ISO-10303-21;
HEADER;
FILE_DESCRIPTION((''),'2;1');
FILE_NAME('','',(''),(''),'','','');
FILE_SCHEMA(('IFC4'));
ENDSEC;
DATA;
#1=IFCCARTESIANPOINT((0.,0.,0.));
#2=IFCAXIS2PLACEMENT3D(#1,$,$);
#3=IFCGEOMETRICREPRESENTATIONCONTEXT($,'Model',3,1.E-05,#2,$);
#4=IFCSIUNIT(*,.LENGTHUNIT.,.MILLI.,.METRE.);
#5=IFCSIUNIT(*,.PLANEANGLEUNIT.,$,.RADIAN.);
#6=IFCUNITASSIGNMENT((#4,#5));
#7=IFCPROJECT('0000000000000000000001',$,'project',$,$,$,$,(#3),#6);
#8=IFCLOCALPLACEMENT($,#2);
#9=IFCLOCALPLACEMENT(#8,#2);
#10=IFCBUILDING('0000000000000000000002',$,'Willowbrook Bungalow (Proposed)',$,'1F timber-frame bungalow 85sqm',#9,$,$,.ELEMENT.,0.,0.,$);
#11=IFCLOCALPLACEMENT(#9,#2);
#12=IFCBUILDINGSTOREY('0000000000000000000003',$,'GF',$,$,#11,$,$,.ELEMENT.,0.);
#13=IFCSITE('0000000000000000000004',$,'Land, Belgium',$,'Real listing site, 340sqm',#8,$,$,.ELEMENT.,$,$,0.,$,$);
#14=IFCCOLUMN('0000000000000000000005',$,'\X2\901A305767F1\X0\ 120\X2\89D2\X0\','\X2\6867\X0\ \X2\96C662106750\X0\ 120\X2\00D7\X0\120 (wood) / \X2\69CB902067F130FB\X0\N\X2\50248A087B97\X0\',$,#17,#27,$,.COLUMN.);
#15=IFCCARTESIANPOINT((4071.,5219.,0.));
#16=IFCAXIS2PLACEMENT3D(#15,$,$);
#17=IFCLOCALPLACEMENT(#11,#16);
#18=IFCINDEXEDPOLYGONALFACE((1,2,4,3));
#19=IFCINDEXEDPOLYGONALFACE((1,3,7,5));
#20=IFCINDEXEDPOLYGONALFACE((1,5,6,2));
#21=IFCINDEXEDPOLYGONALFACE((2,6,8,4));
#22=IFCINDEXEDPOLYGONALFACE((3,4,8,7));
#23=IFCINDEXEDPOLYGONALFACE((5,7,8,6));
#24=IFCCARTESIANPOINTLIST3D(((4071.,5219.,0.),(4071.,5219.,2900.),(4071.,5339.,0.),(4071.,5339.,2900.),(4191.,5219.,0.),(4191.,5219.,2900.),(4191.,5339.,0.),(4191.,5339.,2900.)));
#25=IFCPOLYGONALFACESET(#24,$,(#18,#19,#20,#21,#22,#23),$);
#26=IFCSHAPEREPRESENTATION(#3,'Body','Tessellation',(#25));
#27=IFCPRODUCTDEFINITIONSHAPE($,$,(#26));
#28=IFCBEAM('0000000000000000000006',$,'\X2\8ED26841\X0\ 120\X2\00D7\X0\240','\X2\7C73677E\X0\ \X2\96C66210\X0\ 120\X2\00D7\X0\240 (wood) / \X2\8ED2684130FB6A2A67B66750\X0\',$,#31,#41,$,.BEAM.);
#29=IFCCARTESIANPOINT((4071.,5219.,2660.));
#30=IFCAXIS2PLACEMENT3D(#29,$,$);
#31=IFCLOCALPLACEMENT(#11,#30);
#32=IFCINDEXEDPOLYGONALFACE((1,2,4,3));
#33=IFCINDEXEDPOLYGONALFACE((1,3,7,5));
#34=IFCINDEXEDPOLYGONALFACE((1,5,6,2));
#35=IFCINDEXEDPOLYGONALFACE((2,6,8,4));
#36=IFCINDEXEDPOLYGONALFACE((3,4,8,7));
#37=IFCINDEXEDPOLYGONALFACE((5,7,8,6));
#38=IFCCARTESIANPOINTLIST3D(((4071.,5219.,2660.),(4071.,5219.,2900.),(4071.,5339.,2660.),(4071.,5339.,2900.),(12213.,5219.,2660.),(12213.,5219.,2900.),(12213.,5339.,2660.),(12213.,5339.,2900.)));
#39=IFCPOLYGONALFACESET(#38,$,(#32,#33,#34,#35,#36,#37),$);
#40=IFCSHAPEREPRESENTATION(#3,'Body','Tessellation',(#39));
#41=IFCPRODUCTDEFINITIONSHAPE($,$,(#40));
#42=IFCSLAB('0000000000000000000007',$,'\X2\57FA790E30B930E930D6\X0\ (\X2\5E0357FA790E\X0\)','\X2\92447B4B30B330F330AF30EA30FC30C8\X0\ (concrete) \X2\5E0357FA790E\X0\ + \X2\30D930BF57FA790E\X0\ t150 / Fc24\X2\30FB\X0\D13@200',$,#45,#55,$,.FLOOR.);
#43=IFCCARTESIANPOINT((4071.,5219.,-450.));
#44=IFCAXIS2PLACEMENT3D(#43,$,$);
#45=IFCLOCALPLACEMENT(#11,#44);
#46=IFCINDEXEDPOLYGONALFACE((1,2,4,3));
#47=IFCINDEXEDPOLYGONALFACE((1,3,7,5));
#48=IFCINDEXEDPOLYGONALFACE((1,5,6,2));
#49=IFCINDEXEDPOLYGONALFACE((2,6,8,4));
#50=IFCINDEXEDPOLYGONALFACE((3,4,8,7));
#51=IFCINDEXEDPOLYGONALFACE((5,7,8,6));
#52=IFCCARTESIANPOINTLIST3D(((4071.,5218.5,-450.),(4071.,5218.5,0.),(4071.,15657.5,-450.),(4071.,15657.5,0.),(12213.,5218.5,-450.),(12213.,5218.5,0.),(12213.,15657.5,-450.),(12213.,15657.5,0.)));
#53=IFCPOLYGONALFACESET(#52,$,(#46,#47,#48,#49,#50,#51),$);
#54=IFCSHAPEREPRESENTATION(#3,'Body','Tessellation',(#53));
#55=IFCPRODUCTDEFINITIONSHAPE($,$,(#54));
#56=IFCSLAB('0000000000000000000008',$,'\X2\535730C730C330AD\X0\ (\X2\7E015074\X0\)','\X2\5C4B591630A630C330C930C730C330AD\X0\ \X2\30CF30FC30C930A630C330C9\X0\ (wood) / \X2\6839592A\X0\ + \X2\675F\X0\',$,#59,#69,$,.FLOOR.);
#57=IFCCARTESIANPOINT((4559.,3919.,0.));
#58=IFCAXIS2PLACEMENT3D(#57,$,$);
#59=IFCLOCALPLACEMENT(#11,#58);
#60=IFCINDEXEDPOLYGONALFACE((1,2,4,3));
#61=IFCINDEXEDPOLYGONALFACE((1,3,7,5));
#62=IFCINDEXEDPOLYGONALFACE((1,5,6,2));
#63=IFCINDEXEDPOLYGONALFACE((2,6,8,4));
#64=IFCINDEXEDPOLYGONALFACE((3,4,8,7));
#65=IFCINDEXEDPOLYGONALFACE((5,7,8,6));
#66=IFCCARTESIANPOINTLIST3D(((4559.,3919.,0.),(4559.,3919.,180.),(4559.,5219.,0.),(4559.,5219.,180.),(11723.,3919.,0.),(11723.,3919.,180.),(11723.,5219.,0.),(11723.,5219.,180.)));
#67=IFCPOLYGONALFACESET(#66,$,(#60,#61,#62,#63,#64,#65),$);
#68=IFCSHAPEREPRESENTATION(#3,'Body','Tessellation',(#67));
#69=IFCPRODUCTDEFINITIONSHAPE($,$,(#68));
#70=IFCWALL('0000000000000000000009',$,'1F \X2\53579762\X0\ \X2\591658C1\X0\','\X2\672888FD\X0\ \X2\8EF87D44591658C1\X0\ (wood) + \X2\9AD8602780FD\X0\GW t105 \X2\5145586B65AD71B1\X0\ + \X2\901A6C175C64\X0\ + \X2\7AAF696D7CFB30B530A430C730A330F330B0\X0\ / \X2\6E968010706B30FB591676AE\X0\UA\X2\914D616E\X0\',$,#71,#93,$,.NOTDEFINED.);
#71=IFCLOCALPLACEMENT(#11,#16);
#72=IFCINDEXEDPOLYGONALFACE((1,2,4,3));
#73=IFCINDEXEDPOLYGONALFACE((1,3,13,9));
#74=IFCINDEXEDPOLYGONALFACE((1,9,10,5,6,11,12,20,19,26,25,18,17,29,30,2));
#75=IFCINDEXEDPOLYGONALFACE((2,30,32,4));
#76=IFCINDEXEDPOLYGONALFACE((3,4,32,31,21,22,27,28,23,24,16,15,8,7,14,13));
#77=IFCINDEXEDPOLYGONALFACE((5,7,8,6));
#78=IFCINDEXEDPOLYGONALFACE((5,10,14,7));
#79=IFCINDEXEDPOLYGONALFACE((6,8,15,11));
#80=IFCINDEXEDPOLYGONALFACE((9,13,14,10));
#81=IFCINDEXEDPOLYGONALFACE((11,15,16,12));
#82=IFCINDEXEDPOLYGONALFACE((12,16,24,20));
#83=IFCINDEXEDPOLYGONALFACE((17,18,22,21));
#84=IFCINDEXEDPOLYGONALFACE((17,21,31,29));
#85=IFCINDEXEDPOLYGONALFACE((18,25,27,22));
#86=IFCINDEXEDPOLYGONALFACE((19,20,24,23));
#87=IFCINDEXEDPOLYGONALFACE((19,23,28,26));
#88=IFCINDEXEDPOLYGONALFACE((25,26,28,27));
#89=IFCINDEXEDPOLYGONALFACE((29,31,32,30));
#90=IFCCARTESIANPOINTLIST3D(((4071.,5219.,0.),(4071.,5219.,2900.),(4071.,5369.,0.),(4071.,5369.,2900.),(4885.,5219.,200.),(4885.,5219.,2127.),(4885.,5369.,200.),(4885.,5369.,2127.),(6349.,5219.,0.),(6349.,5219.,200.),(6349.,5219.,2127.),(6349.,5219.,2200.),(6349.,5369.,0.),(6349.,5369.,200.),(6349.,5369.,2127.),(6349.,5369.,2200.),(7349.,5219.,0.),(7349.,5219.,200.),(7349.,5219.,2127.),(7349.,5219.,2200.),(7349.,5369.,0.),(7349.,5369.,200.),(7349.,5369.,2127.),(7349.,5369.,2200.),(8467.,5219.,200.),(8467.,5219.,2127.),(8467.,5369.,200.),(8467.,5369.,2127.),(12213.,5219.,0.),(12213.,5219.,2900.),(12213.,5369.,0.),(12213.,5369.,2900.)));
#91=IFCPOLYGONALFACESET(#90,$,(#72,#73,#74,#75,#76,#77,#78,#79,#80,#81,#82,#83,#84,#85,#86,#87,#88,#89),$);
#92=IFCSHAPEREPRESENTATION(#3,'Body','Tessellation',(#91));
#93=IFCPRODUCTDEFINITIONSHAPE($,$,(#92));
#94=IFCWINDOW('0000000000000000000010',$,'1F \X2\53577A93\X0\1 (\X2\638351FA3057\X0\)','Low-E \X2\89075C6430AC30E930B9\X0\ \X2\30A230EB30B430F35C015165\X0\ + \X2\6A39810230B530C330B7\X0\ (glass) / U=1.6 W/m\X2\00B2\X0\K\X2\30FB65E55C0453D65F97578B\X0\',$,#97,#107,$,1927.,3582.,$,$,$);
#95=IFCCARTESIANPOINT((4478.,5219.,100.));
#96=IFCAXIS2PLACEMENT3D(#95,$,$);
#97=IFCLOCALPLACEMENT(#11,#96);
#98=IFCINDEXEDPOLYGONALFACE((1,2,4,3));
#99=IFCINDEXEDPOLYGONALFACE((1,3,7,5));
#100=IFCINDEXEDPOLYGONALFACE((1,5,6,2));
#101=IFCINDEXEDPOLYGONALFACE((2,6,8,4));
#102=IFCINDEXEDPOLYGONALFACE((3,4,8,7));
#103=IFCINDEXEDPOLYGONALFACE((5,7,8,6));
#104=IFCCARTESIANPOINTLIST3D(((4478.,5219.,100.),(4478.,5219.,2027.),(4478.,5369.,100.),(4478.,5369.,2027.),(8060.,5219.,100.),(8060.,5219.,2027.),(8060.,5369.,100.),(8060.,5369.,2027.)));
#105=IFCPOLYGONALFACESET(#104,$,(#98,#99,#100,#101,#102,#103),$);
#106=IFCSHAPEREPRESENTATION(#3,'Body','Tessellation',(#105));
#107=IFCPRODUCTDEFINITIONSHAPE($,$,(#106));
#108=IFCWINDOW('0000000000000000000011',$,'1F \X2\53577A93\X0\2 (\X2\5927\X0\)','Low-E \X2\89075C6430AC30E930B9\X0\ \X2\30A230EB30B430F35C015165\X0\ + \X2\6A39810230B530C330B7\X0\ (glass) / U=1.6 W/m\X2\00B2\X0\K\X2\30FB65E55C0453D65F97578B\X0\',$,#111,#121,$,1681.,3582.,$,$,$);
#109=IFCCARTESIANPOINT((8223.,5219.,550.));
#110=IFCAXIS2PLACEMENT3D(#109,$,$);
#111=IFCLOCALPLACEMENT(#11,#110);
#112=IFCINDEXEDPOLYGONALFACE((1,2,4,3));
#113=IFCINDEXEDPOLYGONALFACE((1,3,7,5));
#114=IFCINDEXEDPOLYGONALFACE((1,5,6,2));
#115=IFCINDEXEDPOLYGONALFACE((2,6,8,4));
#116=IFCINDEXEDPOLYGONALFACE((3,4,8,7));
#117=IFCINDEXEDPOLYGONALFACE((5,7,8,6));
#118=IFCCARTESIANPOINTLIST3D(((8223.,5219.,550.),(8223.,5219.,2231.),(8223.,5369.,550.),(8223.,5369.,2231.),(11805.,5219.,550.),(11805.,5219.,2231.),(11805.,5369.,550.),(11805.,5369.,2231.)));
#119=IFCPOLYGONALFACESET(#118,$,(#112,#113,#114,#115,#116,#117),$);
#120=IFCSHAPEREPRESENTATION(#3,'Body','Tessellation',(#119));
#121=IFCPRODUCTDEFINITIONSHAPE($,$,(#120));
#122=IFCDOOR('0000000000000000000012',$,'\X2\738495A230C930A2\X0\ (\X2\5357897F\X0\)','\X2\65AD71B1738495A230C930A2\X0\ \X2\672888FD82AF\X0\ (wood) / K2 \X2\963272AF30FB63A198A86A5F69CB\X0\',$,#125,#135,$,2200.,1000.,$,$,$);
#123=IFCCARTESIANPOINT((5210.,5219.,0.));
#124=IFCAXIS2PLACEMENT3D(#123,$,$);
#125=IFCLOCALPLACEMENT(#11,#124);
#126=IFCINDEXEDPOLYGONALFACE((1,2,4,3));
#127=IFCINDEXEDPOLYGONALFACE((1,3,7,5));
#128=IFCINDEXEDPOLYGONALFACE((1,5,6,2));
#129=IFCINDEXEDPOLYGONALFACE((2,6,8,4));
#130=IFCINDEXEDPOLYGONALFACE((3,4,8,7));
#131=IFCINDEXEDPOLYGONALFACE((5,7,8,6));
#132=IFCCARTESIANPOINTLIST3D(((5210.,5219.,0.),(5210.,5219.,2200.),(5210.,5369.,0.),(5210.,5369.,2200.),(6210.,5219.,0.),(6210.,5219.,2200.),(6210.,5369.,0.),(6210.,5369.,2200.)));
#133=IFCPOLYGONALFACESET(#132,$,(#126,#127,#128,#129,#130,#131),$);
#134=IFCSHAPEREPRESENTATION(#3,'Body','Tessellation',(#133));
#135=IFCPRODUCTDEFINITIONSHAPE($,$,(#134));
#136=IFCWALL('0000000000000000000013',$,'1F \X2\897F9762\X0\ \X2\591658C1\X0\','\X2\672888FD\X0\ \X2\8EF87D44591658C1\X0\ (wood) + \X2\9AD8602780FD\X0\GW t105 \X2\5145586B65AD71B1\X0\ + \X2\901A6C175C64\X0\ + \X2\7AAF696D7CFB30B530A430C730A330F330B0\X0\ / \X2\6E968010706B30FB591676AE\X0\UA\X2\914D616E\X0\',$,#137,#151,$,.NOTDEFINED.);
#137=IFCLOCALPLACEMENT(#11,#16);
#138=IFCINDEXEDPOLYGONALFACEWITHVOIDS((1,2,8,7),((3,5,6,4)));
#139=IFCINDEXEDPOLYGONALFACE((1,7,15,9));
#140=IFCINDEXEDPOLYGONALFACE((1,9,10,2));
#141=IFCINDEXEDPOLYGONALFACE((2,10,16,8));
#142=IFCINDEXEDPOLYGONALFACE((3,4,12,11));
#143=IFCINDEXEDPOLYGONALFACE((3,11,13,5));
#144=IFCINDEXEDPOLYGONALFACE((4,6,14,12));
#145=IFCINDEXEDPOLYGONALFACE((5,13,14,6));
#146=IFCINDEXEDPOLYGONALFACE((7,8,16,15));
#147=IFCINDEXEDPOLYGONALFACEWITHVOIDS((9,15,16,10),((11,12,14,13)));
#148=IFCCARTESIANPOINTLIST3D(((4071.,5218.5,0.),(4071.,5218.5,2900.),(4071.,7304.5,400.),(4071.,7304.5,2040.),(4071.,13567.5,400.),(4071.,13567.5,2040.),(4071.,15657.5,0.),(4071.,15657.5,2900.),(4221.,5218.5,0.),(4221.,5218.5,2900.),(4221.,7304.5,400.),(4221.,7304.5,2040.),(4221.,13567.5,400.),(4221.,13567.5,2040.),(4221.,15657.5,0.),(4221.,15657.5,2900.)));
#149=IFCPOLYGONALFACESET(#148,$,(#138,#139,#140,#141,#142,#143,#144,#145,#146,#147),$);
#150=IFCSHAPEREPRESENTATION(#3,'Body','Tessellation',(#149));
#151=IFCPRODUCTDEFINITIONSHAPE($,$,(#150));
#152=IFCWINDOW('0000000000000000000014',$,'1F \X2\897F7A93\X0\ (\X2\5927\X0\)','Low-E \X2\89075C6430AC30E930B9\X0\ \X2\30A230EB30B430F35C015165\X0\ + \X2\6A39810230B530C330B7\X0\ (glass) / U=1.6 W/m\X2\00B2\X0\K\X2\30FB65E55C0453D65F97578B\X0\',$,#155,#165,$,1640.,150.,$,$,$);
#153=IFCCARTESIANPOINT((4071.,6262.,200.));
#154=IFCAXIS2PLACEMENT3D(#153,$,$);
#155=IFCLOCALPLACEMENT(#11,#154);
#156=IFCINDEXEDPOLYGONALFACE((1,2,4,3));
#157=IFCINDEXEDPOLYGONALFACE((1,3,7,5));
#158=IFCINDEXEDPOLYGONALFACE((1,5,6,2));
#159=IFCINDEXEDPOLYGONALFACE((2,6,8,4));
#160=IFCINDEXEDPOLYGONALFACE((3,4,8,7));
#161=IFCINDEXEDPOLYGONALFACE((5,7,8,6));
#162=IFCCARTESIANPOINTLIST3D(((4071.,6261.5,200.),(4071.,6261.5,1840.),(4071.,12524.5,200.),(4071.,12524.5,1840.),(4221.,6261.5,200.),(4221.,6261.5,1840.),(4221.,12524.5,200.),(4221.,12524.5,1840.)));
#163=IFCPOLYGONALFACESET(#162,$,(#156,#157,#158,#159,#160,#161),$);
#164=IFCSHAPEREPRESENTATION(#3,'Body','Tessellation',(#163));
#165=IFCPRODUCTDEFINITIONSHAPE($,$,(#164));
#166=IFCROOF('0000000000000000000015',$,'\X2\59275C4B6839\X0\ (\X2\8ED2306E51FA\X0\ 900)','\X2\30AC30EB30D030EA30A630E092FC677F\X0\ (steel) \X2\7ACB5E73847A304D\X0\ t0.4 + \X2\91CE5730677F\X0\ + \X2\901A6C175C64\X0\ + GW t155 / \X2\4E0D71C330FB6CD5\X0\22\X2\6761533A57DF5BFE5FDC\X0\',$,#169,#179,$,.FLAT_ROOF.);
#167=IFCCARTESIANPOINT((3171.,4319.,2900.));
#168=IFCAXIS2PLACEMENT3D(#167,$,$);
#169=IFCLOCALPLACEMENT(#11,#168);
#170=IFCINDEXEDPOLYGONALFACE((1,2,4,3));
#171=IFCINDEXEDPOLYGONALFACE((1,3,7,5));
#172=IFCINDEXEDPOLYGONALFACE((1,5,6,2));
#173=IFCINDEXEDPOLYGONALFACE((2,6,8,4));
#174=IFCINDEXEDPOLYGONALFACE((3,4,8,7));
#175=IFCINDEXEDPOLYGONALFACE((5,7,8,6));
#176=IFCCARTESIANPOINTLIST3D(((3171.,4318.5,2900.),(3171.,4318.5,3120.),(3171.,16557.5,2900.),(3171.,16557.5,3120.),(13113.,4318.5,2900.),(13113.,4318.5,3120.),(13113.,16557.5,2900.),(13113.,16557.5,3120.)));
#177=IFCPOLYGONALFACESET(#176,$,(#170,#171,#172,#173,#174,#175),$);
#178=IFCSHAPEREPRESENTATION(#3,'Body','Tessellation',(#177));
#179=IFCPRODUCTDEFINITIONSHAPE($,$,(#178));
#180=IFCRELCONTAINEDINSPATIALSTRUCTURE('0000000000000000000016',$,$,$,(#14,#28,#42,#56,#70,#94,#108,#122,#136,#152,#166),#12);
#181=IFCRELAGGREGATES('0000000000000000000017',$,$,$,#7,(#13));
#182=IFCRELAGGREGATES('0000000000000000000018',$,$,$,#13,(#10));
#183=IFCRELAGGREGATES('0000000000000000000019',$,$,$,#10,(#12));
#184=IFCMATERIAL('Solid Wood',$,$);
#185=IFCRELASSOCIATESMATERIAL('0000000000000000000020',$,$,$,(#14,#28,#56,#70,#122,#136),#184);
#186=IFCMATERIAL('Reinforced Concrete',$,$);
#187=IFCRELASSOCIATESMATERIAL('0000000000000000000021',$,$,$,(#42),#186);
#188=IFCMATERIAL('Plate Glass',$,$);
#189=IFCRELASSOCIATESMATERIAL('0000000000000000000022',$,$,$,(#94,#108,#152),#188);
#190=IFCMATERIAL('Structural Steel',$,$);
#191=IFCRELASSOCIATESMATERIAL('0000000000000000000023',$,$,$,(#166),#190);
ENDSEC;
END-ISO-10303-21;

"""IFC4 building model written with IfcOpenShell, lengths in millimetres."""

from ifc_helpers import new_model, si_unit, frame, frame_2d, origin, place, context, project, spatial, rectangle, extrude, material, element, fill, save


model = new_model("IFC4")

# Units and contexts
model_context = context("Model", 3, precision=1e-05, world=origin())
ifc_project = project(units=[si_unit("LENGTHUNIT", "METRE", prefix="MILLI"), si_unit("PLANEANGLEUNIT", "RADIAN")], contexts=[model_context])

# Site, building, storey
site_placement = place(None, origin())
site = spatial("IfcSite", under=ifc_project, at=site_placement, Name="Land, Belgium", ObjectType="Real listing site, 340sqm", CompositionType="ELEMENT", RefElevation=0.0)
building_placement = place(site_placement, origin())
building = spatial("IfcBuilding", under=site, at=building_placement, Name="Willowbrook Bungalow (Proposed)", ObjectType="1F timber-frame bungalow 85sqm", CompositionType="ELEMENT", ElevationOfRefHeight=0.0, ElevationOfTerrain=0.0)
storey_placement = place(building_placement, origin())
storey = spatial("IfcBuildingStorey", under=building, at=storey_placement, Name="GF", CompositionType="ELEMENT", Elevation=0.0)

# Column
ifc_material_1 = material(Name="Solid Wood")
column_1_placement = place(storey_placement, frame((4071.0, 5219.0, 0.0)))
element("IfcColumn", 1, at=column_1_placement, inside=storey, material=ifc_material_1, Name="通し柱 120角", Description="桧 集成材 120×120 (wood) / 構造柱・N値計算", PredefinedType="COLUMN", context=model_context, shape_type="SweptSolid", body=[
    extrude(rectangle(XDim=120.0, YDim=120.0, at=frame_2d((60.0, 60.0))), frame((4071.0, 5219.0, 0.0)), (0.0, 0.0, 1.0), 2900.0),
])

# Beam
beam_1_placement = place(storey_placement, frame((4071.0, 5219.0, 2660.0)))
element("IfcBeam", 2, at=beam_1_placement, inside=storey, material=ifc_material_1, Name="軒桁 120×240", Description="米松 集成 120×240 (wood) / 軒桁・横架材", PredefinedType="BEAM", context=model_context, shape_type="SweptSolid", body=[
    extrude(rectangle(XDim=8142.0, YDim=120.0, at=frame_2d((4071.0, 60.0))), frame((4071.0, 5219.0, 2660.0)), (0.0, 0.0, 1.0), 240.0),
])

# Slabs
ifc_material_2 = material(Name="Reinforced Concrete")
slab_1_placement = place(storey_placement, frame((4071.0, 5219.0, -450.0)))
element("IfcSlab", 3, at=slab_1_placement, inside=storey, material=ifc_material_2, Name="基礎スラブ (布基礎)", Description="鉄筋コンクリート (concrete) 布基礎 + ベタ基礎 t150 / Fc24・D13@200", PredefinedType="FLOOR", context=model_context, shape_type="SweptSolid", body=[
    extrude(rectangle(XDim=8142.0, YDim=10439.0, at=frame_2d((4071.0, 5219.0))), frame((4071.0, 5219.0, -450.0)), (0.0, 0.0, 1.0), 450.0),
])
slab_2_placement = place(storey_placement, frame((4559.0, 3919.0, 0.0)))
element("IfcSlab", 4, at=slab_2_placement, inside=storey, material=ifc_material_1, Name="南デッキ (縁側)", Description="屋外ウッドデッキ ハードウッド (wood) / 根太 + 束", PredefinedType="FLOOR", context=model_context, shape_type="SweptSolid", body=[
    extrude(rectangle(XDim=7164.0, YDim=1300.0, at=frame_2d((3582.0, 650.0))), frame((4559.0, 3919.0, 0.0)), (0.0, 0.0, 1.0), 180.0),
])

# Wall, openings, windows, door
wall_1_placement = place(storey_placement, frame((4071.0, 5219.0, 0.0)))
wall_1 = element("IfcWall", 5, at=wall_1_placement, inside=storey, material=ifc_material_1, Name="1F 南面 外壁", Description="木製 軸組外壁 (wood) + 高性能GW t105 充填断熱 + 通気層 + 窯業系サイディング / 準耐火・外皮UA配慮", PredefinedType="NOTDEFINED", context=model_context, shape_type="SweptSolid", body=[
    extrude(rectangle(XDim=8142.0, YDim=150.0, at=frame_2d((4071.0, 75.0))), frame((4071.0, 5219.0, 0.0)), (0.0, 0.0, 1.0), 2900.0),
])
opening_1_placement = place(storey_placement, frame((4478.0, 5219.0, 100.0)))
opening_1 = element("IfcOpeningElement", 6, at=opening_1_placement, cuts=wall_1, PredefinedType="NOTDEFINED", context=model_context, shape_type="SweptSolid", body=[
    extrude(rectangle(XDim=3582.0, YDim=150.0, at=frame_2d((1791.0, 75.0))), frame((4478.0, 5219.0, 100.0)), (0.0, 0.0, 1.0), 1927.0),
])
opening_2_placement = place(storey_placement, frame((8223.0, 5219.0, 550.0)))
opening_2 = element("IfcOpeningElement", 7, at=opening_2_placement, cuts=wall_1, PredefinedType="NOTDEFINED", context=model_context, shape_type="SweptSolid", body=[
    extrude(rectangle(XDim=3582.0, YDim=150.0, at=frame_2d((1791.0, 75.0))), frame((8223.0, 5219.0, 550.0)), (0.0, 0.0, 1.0), 1681.0),
])
opening_3_placement = place(storey_placement, frame((5210.0, 5219.0, 0.0)))
opening_3 = element("IfcOpeningElement", 8, at=opening_3_placement, cuts=wall_1, PredefinedType="NOTDEFINED", context=model_context, shape_type="SweptSolid", body=[
    extrude(rectangle(XDim=1000.0, YDim=150.0, at=frame_2d((500.0, 75.0))), frame((5210.0, 5219.0, 0.0)), (0.0, 0.0, 1.0), 2200.0),
])
ifc_material_3 = material(Name="Plate Glass")
window_1_placement = place(storey_placement, frame((4478.0, 5219.0, 100.0)))
window_1 = element("IfcWindow", 9, at=window_1_placement, inside=storey, material=ifc_material_3, Name="1F 南窓1 (掃出し)", Description="Low-E 複層ガラス アルゴン封入 + 樹脂サッシ (glass) / U=1.6 W/m²K・日射取得型", OverallHeight=1927.0, OverallWidth=3582.0, context=model_context, shape_type="SweptSolid", body=[
    extrude(rectangle(XDim=3582.0, YDim=150.0, at=frame_2d((1791.0, 75.0))), frame((4478.0, 5219.0, 100.0)), (0.0, 0.0, 1.0), 1927.0),
])
fill(opening_1, window_1)
window_2_placement = place(storey_placement, frame((8223.0, 5219.0, 550.0)))
window_2 = element("IfcWindow", 10, at=window_2_placement, inside=storey, material=ifc_material_3, Name="1F 南窓2 (大)", Description="Low-E 複層ガラス アルゴン封入 + 樹脂サッシ (glass) / U=1.6 W/m²K・日射取得型", OverallHeight=1681.0, OverallWidth=3582.0, context=model_context, shape_type="SweptSolid", body=[
    extrude(rectangle(XDim=3582.0, YDim=150.0, at=frame_2d((1791.0, 75.0))), frame((8223.0, 5219.0, 550.0)), (0.0, 0.0, 1.0), 1681.0),
])
fill(opening_2, window_2)
door_placement = place(storey_placement, frame((5210.0, 5219.0, 0.0)))
door = element("IfcDoor", 11, at=door_placement, inside=storey, material=ifc_material_1, Name="玄関ドア (南西)", Description="断熱玄関ドア 木製芯 (wood) / K2 防犯・採風機構", OverallHeight=2200.0, OverallWidth=1000.0, context=model_context, shape_type="SweptSolid", body=[
    extrude(rectangle(XDim=1000.0, YDim=150.0, at=frame_2d((500.0, 75.0))), frame((5210.0, 5219.0, 0.0)), (0.0, 0.0, 1.0), 2200.0),
])
fill(opening_3, door)

# Wall, opening, window
wall_2_placement = place(storey_placement, frame((4071.0, 5219.0, 0.0)))
wall_2 = element("IfcWall", 12, at=wall_2_placement, inside=storey, material=ifc_material_1, Name="1F 西面 外壁", Description="木製 軸組外壁 (wood) + 高性能GW t105 充填断熱 + 通気層 + 窯業系サイディング / 準耐火・外皮UA配慮", PredefinedType="NOTDEFINED", context=model_context, shape_type="SweptSolid", body=[
    extrude(rectangle(XDim=150.0, YDim=10439.0, at=frame_2d((75.0, 5219.0))), frame((4071.0, 5219.0, 0.0)), (0.0, 0.0, 1.0), 2900.0),
])
opening_4_placement = place(storey_placement, frame((4071.0, 6262.0, 200.0)))
opening_4 = element("IfcOpeningElement", 13, at=opening_4_placement, cuts=wall_2, PredefinedType="NOTDEFINED", context=model_context, shape_type="SweptSolid", body=[
    extrude(rectangle(XDim=150.0, YDim=6263.0, at=frame_2d((75.0, 3131.0))), frame((4071.0, 6262.0, 200.0)), (0.0, 0.0, 1.0), 1640.0),
])
window_3_placement = place(storey_placement, frame((4071.0, 6262.0, 200.0)))
window_3 = element("IfcWindow", 14, at=window_3_placement, inside=storey, material=ifc_material_3, Name="1F 西窓 (大)", Description="Low-E 複層ガラス アルゴン封入 + 樹脂サッシ (glass) / U=1.6 W/m²K・日射取得型", OverallHeight=1640.0, OverallWidth=150.0, context=model_context, shape_type="SweptSolid", body=[
    extrude(rectangle(XDim=150.0, YDim=6263.0, at=frame_2d((75.0, 3131.0))), frame((4071.0, 6262.0, 200.0)), (0.0, 0.0, 1.0), 1640.0),
])
fill(opening_4, window_3)

# Roof
ifc_material_4 = material(Name="Structural Steel")
roof_placement = place(storey_placement, frame((3171.0, 4319.0, 2900.0)))
element("IfcRoof", 15, at=roof_placement, inside=storey, material=ifc_material_4, Name="大屋根 (軒の出 900)", Description="ガルバリウム鋼板 (steel) 立平葺き t0.4 + 野地板 + 通気層 + GW t155 / 不燃・法22条区域対応", PredefinedType="FLAT_ROOF", context=model_context, shape_type="SweptSolid", body=[
    extrude(rectangle(XDim=9942.0, YDim=12239.0, at=frame_2d((4971.0, 6119.0))), frame((3171.0, 4319.0, 2900.0)), (0.0, 0.0, 1.0), 220.0),
])

save(model, "model.ifc")
